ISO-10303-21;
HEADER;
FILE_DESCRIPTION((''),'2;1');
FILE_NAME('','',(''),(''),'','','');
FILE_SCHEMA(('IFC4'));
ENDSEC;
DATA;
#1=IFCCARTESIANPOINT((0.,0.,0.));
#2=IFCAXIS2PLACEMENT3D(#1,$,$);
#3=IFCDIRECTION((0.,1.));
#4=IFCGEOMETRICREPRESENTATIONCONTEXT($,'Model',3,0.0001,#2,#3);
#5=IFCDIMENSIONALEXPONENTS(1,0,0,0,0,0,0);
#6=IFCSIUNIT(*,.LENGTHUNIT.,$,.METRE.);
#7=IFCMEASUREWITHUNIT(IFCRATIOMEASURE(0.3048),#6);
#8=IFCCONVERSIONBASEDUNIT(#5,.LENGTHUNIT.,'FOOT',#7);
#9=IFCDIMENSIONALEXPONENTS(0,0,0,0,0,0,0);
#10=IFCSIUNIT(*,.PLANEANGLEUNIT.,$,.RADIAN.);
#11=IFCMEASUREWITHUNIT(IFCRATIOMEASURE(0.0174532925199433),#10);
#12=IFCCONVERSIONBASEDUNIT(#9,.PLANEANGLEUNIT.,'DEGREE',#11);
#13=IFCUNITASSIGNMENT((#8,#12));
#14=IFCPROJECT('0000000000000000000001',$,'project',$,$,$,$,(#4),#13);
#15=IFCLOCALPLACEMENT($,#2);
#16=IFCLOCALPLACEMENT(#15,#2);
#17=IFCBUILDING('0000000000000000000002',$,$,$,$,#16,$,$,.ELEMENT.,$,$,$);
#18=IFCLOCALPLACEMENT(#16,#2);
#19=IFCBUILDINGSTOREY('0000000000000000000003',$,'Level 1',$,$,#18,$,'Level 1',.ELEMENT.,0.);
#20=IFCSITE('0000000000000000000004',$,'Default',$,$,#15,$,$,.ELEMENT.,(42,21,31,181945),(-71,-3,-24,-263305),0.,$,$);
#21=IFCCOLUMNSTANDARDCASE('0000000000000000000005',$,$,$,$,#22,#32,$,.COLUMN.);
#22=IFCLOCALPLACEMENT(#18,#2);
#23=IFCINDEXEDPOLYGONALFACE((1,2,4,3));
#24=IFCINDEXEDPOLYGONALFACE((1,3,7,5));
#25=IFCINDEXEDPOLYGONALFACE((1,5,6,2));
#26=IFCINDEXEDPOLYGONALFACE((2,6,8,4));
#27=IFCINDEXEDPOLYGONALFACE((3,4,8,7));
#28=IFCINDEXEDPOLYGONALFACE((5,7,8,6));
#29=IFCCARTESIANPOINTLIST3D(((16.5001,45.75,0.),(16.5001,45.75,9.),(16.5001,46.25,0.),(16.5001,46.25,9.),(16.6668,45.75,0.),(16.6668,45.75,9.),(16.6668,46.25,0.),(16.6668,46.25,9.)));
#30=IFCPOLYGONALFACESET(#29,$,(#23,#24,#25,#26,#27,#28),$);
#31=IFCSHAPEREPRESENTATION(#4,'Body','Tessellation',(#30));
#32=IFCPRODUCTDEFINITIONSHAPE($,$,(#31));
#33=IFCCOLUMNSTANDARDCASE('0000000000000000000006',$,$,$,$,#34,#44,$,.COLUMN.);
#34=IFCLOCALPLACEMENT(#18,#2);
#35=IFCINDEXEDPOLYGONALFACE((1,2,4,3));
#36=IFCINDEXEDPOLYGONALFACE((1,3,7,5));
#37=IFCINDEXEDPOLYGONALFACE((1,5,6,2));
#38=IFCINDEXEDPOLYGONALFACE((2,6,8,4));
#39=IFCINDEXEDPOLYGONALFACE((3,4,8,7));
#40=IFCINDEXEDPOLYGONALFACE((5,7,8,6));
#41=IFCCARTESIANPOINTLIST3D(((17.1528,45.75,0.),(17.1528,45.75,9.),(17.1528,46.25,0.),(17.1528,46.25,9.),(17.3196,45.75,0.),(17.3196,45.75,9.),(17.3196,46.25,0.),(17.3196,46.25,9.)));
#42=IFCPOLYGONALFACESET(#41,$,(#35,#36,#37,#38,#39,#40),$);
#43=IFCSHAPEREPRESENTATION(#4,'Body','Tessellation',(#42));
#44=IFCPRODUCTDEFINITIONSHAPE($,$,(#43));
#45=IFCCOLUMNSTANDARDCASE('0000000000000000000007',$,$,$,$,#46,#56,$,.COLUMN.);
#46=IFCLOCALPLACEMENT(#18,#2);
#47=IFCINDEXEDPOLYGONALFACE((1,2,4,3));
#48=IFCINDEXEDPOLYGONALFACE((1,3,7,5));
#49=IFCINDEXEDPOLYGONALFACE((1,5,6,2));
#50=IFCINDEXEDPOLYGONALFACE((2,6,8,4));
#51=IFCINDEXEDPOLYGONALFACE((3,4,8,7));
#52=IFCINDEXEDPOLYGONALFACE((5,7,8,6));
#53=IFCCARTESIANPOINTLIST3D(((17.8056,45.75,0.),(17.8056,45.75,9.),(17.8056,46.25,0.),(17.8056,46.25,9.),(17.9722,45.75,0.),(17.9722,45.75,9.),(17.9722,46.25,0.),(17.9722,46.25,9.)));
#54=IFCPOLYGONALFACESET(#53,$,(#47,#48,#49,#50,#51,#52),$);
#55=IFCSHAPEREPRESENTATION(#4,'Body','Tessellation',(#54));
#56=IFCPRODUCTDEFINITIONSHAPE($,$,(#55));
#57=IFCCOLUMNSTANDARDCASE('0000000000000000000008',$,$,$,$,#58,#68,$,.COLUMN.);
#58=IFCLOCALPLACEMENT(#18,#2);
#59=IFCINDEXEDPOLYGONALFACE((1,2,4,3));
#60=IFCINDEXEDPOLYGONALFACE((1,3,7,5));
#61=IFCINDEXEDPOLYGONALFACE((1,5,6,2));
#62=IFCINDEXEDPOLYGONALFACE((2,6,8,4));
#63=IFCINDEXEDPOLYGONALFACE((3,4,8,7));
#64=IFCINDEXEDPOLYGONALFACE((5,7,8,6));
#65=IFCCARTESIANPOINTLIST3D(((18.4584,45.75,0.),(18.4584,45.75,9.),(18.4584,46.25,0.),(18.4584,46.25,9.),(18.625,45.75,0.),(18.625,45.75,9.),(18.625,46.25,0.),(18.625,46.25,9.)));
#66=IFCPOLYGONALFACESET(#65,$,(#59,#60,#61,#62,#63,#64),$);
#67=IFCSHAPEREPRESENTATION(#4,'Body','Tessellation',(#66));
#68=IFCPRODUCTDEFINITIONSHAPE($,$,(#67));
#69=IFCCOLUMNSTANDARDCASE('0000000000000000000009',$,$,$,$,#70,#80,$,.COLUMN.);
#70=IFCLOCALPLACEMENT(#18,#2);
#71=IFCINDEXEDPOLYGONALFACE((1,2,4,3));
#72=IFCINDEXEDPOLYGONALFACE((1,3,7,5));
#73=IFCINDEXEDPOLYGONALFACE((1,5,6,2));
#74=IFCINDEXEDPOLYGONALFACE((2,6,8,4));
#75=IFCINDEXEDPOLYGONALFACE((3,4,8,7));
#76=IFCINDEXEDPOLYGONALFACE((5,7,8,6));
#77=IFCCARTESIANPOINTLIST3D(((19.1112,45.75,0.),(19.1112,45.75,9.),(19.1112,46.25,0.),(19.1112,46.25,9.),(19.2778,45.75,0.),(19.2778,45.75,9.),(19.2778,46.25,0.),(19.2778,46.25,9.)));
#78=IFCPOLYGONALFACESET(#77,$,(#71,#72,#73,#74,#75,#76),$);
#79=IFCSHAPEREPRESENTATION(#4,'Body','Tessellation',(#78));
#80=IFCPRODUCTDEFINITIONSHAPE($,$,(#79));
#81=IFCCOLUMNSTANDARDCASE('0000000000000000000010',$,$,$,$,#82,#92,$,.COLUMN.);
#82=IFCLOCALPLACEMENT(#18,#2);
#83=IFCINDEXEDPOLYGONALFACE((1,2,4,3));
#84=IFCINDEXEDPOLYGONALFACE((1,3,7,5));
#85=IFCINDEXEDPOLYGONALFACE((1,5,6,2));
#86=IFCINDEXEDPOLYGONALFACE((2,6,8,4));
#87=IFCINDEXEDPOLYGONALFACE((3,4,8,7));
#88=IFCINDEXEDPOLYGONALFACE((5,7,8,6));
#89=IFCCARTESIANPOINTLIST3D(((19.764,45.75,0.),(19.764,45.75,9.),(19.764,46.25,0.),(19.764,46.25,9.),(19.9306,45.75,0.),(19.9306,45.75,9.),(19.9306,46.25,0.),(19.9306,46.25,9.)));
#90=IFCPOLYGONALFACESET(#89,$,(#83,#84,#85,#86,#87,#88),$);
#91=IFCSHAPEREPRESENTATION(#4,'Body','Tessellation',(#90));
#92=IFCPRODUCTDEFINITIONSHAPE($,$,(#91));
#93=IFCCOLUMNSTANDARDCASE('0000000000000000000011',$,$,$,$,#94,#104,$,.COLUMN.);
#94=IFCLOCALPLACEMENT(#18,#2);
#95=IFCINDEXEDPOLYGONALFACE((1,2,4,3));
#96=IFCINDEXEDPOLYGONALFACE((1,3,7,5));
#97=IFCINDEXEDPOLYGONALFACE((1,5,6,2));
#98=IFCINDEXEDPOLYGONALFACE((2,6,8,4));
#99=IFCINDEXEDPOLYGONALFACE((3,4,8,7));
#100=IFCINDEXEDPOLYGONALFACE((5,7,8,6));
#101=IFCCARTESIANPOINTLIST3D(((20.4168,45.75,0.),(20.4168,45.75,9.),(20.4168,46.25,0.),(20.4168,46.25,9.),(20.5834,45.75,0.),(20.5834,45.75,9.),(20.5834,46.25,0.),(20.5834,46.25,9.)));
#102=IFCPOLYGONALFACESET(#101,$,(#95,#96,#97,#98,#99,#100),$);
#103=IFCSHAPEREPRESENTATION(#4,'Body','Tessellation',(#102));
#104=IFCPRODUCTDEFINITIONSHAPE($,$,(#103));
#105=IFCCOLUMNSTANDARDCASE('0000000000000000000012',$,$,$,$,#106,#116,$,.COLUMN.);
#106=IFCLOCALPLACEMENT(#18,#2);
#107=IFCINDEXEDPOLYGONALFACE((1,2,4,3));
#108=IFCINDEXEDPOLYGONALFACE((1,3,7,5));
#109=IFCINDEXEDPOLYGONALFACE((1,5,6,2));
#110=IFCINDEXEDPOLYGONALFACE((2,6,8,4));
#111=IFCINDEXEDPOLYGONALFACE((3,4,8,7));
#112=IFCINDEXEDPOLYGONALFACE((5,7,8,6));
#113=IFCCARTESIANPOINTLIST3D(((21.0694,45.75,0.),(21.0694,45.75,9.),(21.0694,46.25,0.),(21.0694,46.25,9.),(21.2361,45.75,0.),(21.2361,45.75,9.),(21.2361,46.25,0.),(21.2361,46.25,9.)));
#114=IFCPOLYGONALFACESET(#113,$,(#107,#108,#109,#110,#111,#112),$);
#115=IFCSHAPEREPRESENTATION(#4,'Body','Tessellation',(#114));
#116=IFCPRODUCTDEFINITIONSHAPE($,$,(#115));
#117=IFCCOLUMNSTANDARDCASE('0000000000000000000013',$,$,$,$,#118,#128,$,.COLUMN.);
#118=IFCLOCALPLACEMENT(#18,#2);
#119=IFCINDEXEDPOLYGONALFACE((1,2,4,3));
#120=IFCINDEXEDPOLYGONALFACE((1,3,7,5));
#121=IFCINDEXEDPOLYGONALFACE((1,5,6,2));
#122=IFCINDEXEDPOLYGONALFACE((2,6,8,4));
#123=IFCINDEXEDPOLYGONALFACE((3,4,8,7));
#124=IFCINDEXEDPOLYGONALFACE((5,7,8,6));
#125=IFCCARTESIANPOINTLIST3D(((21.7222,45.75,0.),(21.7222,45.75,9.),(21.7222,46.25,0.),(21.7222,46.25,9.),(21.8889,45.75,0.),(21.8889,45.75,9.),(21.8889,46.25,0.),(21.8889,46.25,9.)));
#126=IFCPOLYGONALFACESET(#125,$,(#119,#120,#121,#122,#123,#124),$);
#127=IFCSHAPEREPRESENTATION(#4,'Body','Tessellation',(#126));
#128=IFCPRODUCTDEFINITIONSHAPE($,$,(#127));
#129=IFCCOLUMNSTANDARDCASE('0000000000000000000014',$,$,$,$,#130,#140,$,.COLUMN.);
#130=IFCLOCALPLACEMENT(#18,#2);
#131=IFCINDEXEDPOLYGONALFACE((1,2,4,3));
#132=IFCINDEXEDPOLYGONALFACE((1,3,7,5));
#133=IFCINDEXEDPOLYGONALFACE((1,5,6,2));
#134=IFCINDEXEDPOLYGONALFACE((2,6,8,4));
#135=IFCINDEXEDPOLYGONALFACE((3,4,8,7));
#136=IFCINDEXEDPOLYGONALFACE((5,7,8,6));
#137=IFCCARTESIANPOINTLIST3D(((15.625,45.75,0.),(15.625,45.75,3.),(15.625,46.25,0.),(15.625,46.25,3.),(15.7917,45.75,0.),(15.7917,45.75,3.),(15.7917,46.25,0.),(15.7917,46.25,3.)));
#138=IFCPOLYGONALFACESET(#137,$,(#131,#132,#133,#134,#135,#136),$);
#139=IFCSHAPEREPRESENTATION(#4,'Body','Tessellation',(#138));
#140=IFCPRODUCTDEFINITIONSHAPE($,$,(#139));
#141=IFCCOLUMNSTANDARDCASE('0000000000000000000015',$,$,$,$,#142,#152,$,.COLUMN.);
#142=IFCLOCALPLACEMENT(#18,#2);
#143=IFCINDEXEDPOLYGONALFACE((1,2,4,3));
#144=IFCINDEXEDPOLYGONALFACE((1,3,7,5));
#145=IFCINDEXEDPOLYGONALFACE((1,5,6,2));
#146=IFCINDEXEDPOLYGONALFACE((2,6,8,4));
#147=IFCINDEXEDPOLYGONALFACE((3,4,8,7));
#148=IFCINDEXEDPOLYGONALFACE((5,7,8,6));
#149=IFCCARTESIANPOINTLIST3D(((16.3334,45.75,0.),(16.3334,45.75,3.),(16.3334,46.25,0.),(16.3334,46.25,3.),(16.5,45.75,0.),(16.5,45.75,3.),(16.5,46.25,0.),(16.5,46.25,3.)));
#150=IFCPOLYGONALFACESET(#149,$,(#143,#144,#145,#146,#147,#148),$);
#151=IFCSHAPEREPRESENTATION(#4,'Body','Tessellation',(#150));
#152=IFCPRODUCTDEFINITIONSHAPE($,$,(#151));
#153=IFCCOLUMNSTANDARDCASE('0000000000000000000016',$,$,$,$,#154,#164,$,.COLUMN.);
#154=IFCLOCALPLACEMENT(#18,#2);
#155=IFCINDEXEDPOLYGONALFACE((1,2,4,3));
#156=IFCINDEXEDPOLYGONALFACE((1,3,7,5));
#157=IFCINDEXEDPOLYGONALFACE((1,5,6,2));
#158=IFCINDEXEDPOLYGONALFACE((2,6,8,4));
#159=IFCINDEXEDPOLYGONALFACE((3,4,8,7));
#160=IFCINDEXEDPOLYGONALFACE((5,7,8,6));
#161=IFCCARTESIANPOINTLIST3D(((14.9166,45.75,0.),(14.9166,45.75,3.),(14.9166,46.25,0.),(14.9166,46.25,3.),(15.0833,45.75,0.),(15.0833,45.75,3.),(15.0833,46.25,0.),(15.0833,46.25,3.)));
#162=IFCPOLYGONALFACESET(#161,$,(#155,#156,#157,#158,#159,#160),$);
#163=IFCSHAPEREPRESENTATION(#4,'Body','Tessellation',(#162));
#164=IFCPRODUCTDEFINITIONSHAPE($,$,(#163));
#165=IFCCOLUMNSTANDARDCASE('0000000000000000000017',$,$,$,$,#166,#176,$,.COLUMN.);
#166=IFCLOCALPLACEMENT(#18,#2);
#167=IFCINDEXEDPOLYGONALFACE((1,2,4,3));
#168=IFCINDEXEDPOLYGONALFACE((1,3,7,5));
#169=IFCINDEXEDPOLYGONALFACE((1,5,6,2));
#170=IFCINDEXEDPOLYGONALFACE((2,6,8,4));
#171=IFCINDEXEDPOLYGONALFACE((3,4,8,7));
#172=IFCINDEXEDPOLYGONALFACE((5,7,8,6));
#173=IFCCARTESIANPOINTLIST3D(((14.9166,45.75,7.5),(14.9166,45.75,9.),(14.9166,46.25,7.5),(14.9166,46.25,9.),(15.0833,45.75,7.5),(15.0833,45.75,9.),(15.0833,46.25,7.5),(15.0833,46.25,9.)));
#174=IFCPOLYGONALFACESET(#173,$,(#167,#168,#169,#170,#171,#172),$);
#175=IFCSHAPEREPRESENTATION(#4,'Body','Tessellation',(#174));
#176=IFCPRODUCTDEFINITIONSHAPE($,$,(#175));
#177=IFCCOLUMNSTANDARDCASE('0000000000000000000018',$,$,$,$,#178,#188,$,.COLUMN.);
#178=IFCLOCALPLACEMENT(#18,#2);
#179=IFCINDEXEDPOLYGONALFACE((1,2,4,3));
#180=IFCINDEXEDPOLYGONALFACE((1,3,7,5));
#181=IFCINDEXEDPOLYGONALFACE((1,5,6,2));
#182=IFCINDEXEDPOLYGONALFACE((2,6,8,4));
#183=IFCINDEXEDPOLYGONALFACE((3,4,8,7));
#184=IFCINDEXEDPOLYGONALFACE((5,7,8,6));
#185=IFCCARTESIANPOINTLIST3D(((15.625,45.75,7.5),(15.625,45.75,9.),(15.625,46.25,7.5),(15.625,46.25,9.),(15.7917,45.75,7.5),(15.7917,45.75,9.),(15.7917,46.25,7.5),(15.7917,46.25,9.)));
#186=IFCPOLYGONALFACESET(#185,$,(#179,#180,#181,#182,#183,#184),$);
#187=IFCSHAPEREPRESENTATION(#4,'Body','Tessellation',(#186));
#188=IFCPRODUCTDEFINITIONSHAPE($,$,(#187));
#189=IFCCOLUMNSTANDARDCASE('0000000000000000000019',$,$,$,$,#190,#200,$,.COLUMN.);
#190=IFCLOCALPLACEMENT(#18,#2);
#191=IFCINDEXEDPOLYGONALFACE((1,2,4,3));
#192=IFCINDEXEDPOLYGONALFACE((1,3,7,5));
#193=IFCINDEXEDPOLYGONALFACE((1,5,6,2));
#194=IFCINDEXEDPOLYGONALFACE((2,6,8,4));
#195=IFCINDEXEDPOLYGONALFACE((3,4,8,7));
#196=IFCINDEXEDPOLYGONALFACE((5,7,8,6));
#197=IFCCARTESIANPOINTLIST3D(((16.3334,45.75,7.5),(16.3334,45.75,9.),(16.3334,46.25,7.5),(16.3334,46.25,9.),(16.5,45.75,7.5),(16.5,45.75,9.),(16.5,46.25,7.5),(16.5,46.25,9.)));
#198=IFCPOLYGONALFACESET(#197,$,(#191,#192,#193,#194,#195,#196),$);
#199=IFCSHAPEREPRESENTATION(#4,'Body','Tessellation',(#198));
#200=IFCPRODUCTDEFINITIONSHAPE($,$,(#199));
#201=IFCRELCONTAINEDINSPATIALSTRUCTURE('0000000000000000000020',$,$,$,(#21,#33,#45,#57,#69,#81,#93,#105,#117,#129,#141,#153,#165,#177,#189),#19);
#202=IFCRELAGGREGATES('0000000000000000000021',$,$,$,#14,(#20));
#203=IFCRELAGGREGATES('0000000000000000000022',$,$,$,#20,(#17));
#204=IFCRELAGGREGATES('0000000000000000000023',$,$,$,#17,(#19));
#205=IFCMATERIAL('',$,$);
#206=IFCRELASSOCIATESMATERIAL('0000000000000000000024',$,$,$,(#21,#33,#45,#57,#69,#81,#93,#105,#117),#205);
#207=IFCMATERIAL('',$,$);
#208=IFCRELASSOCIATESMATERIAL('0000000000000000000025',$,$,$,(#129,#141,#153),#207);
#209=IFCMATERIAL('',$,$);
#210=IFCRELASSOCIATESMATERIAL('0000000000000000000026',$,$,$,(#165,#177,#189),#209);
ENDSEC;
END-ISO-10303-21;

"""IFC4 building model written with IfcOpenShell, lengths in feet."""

from ifc_helpers import new_model, entity, si_unit, converted_unit, direction, frame, origin, place, context, project, spatial, rectangle, extrude, material, element, save


model = new_model("IFC4")

# Units and contexts
model_context = context("Model", 3, precision=0.0001, world=origin(), true_north=direction((0.0, 1.0)))
ifc_project = project(units=[converted_unit("LENGTHUNIT", "FOOT", entity("IfcRatioMeasure", 0.3048), si_unit("LENGTHUNIT", "METRE"), dimensions=[1, 0, 0, 0, 0, 0, 0]), converted_unit("PLANEANGLEUNIT", "DEGREE", entity("IfcRatioMeasure", 0.0174532925199433), si_unit("PLANEANGLEUNIT", "RADIAN"), dimensions=[0, 0, 0, 0, 0, 0, 0])], contexts=[model_context])

# Site, building, storey
site_placement = place(None, origin())
site = spatial("IfcSite", under=ifc_project, at=site_placement, Name="Default", CompositionType="ELEMENT", RefLatitude=(42, 21, 31, 181945), RefLongitude=(-71, -3, -24, -263305), RefElevation=0.0)
building_placement = place(site_placement, origin())
building = spatial("IfcBuilding", under=site, at=building_placement, CompositionType="ELEMENT")
storey_placement = place(building_placement, origin())
storey = spatial("IfcBuildingStorey", under=building, at=storey_placement, Name="Level 1", LongName="Level 1", CompositionType="ELEMENT", Elevation=0.0)

# Columns
ifc_material_1 = material(Name="")
placement_1 = place(storey_placement, frame((-0.25, 46.0, 0.0)))
for number, where, z_axis, x_axis in (
    (1, (16.8334, 0.0, 0.0), (0.0, 0.0, 1.0), (1.0, 0.0, 0.0)),
    (2, (17.4862, 0.0, 0.0), (0.0, 0.0, 1.0), (1.0, 0.0, 0.0)),
    (3, (18.1389, 0.0, 0.0), (0.0, 0.0, 1.0), (1.0, 0.0, 0.0)),
    (4, (18.7917, 0.0, 0.0), (0.0, 0.0, 1.0), (1.0, 0.0, 0.0)),
    (5, (19.4445, 0.0, 0.0), (0.0, 0.0, 1.0), (1.0, 0.0, 0.0)),
    (6, (20.0973, 0.0, 0.0), (0.0, 0.0, 1.0), (1.0, 0.0, 0.0)),
    (7, (20.7501, 0.0, 0.0), (0.0, 0.0, 1.0), (1.0, 0.0, 0.0)),
    (8, (21.4028, 0.0, 0.0), (0.0, 0.0, 1.0), (1.0, 0.0, 0.0)),
    (9, (22.0556, 0.0, 0.0), (0.0, 0.0, 1.0), (1.0, 0.0, 0.0)),
):
    element("IfcColumnStandardCase", number, at=place(placement_1, frame(where, z_axis=z_axis, x_axis=x_axis)), inside=storey, material=ifc_material_1, PredefinedType="COLUMN", context=model_context, shape_type="SweptSolid", body=[
        extrude(rectangle(XDim=0.1667, YDim=0.5), origin(), (0.0, 0.0, 1.0), 9.0),
    ])
ifc_material_2 = material(Name="")
for number, where, z_axis, x_axis in (
    (10, (15.9584, 0.0, 0.0), (0.0, 0.0, 1.0), (1.0, 0.0, 0.0)),
    (11, (16.6667, 0.0, 0.0), (0.0, 0.0, 1.0), (1.0, 0.0, 0.0)),
    (12, (15.25, 0.0, 0.0), (0.0, 0.0, 1.0), (1.0, 0.0, 0.0)),
):
    element("IfcColumnStandardCase", number, at=place(placement_1, frame(where, z_axis=z_axis, x_axis=x_axis)), inside=storey, material=ifc_material_2, PredefinedType="COLUMN", context=model_context, shape_type="SweptSolid", body=[
        extrude(rectangle(XDim=0.1667, YDim=0.5), origin(), (0.0, 0.0, 1.0), 3.0),
    ])
ifc_material_3 = material(Name="")
for number, where, z_axis, x_axis in (
    (13, (15.25, 0.0, 7.5), (0.0, 0.0, 1.0), (1.0, 0.0, 0.0)),
    (14, (15.9584, 0.0, 7.5), (0.0, 0.0, 1.0), (1.0, 0.0, 0.0)),
    (15, (16.6667, 0.0, 7.5), (0.0, 0.0, 1.0), (1.0, 0.0, 0.0)),
):
    element("IfcColumnStandardCase", number, at=place(placement_1, frame(where, z_axis=z_axis, x_axis=x_axis)), inside=storey, material=ifc_material_3, PredefinedType="COLUMN", context=model_context, shape_type="SweptSolid", body=[
        extrude(rectangle(XDim=0.1667, YDim=0.5), origin(), (0.0, 0.0, 1.0), 1.5),
    ])

save(model, "model.ifc")
